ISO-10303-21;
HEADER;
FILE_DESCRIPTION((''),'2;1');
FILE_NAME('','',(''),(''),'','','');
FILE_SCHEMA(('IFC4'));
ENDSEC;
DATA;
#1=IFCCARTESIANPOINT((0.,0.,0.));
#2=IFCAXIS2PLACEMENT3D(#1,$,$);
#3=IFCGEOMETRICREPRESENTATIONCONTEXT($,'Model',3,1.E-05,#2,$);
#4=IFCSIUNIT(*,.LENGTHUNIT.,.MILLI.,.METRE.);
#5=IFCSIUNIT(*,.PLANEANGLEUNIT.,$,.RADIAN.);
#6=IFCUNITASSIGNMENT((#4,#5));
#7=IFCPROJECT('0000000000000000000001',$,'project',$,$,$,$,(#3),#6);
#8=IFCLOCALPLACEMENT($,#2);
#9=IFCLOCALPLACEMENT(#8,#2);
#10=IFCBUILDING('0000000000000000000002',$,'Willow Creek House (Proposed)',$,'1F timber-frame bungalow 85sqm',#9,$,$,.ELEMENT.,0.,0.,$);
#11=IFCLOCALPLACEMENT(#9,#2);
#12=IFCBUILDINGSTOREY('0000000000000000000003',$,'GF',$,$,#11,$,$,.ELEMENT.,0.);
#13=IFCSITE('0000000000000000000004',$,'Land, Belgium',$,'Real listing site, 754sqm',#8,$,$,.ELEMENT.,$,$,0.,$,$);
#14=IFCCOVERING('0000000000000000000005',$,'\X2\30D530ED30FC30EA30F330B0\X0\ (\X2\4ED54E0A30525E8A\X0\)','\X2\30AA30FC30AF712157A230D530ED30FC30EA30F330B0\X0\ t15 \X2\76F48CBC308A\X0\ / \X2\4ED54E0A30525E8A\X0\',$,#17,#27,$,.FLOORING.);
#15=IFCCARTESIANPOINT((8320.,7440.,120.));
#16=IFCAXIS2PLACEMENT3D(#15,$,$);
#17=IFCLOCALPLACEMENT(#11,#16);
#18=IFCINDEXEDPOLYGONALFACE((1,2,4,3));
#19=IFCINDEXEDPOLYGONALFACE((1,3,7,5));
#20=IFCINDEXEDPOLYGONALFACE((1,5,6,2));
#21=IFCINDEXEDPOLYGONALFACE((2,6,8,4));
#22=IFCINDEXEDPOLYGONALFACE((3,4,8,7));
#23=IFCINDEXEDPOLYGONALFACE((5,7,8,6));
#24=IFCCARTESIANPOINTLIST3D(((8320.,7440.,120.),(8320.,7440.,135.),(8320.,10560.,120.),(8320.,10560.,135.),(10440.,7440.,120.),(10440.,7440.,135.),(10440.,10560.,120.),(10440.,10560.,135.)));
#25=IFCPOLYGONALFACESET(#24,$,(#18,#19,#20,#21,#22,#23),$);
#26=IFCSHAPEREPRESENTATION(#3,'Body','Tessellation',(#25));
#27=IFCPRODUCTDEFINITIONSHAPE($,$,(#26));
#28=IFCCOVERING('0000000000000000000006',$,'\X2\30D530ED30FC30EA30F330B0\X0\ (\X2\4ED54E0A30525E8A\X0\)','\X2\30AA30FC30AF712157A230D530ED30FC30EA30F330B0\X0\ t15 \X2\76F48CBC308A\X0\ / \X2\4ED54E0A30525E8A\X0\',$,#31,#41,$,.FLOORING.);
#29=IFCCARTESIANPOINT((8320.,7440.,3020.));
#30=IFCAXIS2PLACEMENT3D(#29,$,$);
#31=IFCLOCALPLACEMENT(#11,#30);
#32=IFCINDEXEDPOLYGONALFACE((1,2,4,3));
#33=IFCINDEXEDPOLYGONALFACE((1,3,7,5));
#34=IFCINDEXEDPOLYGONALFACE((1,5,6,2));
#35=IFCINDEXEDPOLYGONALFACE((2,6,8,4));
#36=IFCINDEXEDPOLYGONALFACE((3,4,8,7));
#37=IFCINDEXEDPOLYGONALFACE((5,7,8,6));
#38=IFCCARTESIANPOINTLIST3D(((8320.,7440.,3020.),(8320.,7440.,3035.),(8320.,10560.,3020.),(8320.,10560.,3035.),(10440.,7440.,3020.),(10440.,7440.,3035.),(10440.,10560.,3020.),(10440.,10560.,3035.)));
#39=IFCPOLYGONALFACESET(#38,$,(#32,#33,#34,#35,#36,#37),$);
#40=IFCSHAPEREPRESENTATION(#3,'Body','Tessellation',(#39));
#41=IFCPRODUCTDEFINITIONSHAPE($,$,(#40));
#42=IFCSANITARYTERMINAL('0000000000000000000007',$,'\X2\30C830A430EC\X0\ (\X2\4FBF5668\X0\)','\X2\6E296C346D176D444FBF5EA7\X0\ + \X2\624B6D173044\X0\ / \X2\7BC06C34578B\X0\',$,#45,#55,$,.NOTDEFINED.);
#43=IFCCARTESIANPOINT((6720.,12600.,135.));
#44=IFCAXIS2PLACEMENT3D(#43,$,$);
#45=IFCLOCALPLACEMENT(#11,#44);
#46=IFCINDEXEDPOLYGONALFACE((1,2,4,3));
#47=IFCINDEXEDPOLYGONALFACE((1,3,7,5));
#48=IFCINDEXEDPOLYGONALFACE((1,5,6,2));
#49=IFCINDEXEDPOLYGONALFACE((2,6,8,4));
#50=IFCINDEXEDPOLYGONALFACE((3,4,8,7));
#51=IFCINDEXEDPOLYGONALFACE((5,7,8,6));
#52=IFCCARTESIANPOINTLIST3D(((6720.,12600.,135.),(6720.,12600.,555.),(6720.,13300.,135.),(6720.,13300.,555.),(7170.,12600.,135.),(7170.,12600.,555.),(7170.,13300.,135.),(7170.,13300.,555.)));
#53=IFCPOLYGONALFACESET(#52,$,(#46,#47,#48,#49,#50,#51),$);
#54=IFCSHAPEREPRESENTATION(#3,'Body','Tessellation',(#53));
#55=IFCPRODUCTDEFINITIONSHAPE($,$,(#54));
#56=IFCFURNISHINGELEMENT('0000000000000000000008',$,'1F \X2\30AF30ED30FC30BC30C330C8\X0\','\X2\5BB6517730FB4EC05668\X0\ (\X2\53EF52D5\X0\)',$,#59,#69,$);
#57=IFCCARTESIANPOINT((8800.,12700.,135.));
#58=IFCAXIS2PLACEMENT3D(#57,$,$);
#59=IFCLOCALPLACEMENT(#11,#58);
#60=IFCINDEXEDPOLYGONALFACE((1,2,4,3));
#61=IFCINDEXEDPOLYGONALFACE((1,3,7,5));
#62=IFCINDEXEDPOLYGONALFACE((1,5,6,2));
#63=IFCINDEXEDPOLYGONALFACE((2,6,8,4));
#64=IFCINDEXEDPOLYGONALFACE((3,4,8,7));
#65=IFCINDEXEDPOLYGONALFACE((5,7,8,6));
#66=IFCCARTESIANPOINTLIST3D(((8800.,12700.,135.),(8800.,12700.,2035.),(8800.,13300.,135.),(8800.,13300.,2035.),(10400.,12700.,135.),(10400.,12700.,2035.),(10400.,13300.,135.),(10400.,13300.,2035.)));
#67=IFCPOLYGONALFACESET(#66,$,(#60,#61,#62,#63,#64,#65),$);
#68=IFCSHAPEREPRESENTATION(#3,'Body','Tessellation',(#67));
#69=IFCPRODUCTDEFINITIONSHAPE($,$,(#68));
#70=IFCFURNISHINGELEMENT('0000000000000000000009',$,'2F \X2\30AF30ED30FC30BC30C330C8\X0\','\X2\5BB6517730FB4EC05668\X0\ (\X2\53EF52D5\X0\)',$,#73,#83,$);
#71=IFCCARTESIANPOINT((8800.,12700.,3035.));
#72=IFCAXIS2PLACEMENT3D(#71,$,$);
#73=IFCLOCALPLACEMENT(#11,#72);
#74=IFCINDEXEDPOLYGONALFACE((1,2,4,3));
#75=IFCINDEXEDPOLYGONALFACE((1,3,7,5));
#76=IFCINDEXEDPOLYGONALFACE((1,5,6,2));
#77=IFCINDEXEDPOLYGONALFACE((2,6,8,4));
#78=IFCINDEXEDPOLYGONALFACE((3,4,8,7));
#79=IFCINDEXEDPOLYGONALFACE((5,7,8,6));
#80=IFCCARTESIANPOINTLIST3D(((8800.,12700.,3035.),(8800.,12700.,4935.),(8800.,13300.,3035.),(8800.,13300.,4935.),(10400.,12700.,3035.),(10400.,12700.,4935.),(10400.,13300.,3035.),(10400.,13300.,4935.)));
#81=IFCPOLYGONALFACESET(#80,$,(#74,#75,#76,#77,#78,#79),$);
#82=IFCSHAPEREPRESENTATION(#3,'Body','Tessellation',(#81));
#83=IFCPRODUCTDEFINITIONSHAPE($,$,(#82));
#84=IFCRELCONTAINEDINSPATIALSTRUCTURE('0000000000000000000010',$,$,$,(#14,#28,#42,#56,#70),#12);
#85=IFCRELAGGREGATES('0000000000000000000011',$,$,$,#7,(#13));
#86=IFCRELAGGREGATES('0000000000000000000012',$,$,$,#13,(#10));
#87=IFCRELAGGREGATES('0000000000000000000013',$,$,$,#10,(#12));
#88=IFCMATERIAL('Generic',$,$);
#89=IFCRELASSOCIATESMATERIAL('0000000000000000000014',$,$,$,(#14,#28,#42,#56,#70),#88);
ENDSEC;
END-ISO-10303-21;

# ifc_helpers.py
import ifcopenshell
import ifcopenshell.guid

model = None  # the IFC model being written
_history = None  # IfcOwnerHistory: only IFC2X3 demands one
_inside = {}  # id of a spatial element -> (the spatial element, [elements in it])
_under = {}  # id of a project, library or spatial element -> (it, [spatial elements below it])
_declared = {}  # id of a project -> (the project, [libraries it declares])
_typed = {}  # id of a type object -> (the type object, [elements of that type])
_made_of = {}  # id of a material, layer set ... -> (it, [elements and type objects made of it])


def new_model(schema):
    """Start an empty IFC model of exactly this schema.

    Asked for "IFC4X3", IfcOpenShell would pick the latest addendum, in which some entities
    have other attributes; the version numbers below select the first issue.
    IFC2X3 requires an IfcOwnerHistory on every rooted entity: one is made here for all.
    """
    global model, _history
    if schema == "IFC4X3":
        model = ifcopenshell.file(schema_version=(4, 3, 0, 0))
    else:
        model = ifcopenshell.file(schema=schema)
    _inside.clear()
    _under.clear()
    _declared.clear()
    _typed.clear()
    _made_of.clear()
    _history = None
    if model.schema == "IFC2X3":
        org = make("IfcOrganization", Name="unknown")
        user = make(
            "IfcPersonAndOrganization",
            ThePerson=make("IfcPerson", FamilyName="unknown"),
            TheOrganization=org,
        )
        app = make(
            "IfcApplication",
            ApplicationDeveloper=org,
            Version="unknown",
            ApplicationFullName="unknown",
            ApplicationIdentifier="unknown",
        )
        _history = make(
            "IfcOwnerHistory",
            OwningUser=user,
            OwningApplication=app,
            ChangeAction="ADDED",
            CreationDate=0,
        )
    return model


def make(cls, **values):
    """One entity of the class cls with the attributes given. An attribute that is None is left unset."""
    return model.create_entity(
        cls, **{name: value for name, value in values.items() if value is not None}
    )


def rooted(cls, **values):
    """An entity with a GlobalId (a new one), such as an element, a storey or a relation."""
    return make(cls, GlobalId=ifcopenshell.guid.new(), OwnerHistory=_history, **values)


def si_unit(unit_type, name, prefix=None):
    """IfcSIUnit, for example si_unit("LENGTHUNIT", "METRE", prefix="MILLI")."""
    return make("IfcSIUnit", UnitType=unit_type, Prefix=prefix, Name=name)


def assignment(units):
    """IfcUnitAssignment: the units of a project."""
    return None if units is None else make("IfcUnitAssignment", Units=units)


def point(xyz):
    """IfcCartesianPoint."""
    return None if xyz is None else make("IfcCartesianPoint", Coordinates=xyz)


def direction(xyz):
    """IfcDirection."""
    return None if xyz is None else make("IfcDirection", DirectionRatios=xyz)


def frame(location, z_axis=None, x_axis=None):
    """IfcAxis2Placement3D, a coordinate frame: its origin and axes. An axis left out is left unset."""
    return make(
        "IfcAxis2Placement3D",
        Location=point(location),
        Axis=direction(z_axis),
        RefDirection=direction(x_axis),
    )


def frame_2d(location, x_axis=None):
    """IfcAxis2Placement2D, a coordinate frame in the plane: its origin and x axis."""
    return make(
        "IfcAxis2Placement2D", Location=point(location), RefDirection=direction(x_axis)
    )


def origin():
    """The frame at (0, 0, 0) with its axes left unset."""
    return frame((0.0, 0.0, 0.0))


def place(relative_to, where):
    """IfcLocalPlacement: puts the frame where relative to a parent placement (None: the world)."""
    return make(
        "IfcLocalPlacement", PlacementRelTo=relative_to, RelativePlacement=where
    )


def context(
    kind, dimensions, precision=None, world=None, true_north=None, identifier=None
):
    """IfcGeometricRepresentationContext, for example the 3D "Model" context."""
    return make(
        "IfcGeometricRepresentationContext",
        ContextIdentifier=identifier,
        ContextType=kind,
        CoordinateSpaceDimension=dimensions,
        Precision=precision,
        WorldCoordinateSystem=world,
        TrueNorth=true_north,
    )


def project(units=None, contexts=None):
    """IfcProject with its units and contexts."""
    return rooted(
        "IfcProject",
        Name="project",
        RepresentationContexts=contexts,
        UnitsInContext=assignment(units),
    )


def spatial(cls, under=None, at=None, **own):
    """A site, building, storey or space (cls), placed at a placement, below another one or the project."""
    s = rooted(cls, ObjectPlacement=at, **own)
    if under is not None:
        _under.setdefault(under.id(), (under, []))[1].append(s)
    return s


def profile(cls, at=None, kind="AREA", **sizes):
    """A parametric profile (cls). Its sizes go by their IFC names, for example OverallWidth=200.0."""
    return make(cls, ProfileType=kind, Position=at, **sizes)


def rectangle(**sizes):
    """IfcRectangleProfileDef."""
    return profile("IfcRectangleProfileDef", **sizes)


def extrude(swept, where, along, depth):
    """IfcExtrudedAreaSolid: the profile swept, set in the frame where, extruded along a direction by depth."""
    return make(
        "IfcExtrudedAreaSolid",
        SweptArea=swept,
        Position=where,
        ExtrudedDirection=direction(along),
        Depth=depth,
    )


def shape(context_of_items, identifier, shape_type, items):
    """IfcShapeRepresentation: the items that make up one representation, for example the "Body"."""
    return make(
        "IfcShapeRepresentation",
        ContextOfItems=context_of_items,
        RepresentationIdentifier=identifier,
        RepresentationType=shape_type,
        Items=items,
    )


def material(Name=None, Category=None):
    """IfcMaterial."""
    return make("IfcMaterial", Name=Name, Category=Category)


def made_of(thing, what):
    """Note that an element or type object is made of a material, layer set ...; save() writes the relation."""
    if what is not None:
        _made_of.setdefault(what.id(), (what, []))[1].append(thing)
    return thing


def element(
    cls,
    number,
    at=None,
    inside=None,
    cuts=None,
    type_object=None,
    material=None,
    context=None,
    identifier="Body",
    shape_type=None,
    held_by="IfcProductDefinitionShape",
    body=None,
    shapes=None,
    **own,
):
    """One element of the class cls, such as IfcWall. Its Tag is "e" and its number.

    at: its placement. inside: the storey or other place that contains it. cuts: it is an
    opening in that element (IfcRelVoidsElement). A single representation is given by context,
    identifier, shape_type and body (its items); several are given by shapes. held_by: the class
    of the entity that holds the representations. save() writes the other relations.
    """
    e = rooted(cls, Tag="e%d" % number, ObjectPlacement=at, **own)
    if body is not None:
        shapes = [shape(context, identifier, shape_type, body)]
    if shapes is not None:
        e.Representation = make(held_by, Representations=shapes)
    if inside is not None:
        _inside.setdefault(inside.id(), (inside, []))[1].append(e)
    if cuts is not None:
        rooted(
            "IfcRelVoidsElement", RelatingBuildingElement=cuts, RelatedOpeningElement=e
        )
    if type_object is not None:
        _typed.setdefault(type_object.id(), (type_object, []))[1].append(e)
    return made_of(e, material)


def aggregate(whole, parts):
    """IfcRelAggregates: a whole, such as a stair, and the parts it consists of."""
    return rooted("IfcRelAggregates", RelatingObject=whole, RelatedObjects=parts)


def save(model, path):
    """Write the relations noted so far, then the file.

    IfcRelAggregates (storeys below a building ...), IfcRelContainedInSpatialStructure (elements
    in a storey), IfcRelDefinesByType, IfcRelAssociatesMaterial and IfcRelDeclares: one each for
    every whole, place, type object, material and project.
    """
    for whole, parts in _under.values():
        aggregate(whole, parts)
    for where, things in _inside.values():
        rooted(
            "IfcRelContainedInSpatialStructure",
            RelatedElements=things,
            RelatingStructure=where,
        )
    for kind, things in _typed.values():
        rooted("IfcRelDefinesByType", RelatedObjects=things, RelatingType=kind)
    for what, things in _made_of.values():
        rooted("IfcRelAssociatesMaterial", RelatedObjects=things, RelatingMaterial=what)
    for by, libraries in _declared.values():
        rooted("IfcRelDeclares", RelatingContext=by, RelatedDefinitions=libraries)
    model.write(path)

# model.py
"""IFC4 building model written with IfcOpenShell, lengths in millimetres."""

from ifc_helpers import new_model, si_unit, frame, frame_2d, origin, place, context, project, spatial, rectangle, extrude, material, element, save


model = new_model("IFC4")

# Units and contexts
model_context = context("Model", 3, precision=1e-05, world=origin())
ifc_project = project(units=[si_unit("LENGTHUNIT", "METRE", prefix="MILLI"), si_unit("PLANEANGLEUNIT", "RADIAN")], contexts=[model_context])

# Site, building, storey
site_placement = place(None, origin())
site = spatial("IfcSite", under=ifc_project, at=site_placement, Name="Land, Belgium", ObjectType="Real listing site, 754sqm", CompositionType="ELEMENT", RefElevation=0.0)
building_placement = place(site_placement, origin())
building = spatial("IfcBuilding", under=site, at=building_placement, Name="Willow Creek House (Proposed)", ObjectType="1F timber-frame bungalow 85sqm", CompositionType="ELEMENT", ElevationOfRefHeight=0.0, ElevationOfTerrain=0.0)
storey_placement = place(building_placement, origin())
storey = spatial("IfcBuildingStorey", under=building, at=storey_placement, Name="GF", CompositionType="ELEMENT", Elevation=0.0)

# Shared definitions
ifc_material_1 = material(Name="Generic")

# Coverings
covering_1_placement = place(storey_placement, frame((8320.0, 7440.0, 120.0)))
element("IfcCovering", 1, at=covering_1_placement, inside=storey, material=ifc_material_1, Name="フローリング (仕上げ床)", Description="オーク無垢フローリング t15 直貼り / 仕上げ床", PredefinedType="FLOORING", context=model_context, shape_type="SweptSolid", body=[
    extrude(rectangle(XDim=2120.0, YDim=3120.0, at=frame_2d((1060.0, 1560.0))), frame((8320.0, 7440.0, 120.0)), (0.0, 0.0, 1.0), 15.0),
])
covering_2_placement = place(storey_placement, frame((8320.0, 7440.0, 3020.0)))
element("IfcCovering", 2, at=covering_2_placement, inside=storey, material=ifc_material_1, Name="フローリング (仕上げ床)", Description="オーク無垢フローリング t15 直貼り / 仕上げ床", PredefinedType="FLOORING", context=model_context, shape_type="SweptSolid", body=[
    extrude(rectangle(XDim=2120.0, YDim=3120.0, at=frame_2d((1060.0, 1560.0))), frame((8320.0, 7440.0, 3020.0)), (0.0, 0.0, 1.0), 15.0),
])

# Sanitary terminal
sanitary_terminal_placement = place(storey_placement, frame((6720.0, 12600.0, 135.0)))
element("IfcSanitaryTerminal", 3, at=sanitary_terminal_placement, inside=storey, material=ifc_material_1, Name="トイレ (便器)", Description="温水洗浄便座 + 手洗い / 節水型", PredefinedType="NOTDEFINED", context=model_context, shape_type="SweptSolid", body=[
    extrude(rectangle(XDim=450.0, YDim=700.0, at=frame_2d((225.0, 350.0))), frame((6720.0, 12600.0, 135.0)), (0.0, 0.0, 1.0), 420.0),
])

# Furnishing elements
furnishing_1_placement = place(storey_placement, frame((8800.0, 12700.0, 135.0)))
element("IfcFurnishingElement", 4, at=furnishing_1_placement, inside=storey, material=ifc_material_1, Name="1F クローゼット", Description="家具・什器 (可動)", context=model_context, shape_type="SweptSolid", body=[
    extrude(rectangle(XDim=1600.0, YDim=600.0, at=frame_2d((800.0, 300.0))), frame((8800.0, 12700.0, 135.0)), (0.0, 0.0, 1.0), 1900.0),
])
furnishing_2_placement = place(storey_placement, frame((8800.0, 12700.0, 3035.0)))
element("IfcFurnishingElement", 5, at=furnishing_2_placement, inside=storey, material=ifc_material_1, Name="2F クローゼット", Description="家具・什器 (可動)", context=model_context, shape_type="SweptSolid", body=[
    extrude(rectangle(XDim=1600.0, YDim=600.0, at=frame_2d((800.0, 300.0))), frame((8800.0, 12700.0, 3035.0)), (0.0, 0.0, 1.0), 1900.0),
])

save(model, "model.ifc")
